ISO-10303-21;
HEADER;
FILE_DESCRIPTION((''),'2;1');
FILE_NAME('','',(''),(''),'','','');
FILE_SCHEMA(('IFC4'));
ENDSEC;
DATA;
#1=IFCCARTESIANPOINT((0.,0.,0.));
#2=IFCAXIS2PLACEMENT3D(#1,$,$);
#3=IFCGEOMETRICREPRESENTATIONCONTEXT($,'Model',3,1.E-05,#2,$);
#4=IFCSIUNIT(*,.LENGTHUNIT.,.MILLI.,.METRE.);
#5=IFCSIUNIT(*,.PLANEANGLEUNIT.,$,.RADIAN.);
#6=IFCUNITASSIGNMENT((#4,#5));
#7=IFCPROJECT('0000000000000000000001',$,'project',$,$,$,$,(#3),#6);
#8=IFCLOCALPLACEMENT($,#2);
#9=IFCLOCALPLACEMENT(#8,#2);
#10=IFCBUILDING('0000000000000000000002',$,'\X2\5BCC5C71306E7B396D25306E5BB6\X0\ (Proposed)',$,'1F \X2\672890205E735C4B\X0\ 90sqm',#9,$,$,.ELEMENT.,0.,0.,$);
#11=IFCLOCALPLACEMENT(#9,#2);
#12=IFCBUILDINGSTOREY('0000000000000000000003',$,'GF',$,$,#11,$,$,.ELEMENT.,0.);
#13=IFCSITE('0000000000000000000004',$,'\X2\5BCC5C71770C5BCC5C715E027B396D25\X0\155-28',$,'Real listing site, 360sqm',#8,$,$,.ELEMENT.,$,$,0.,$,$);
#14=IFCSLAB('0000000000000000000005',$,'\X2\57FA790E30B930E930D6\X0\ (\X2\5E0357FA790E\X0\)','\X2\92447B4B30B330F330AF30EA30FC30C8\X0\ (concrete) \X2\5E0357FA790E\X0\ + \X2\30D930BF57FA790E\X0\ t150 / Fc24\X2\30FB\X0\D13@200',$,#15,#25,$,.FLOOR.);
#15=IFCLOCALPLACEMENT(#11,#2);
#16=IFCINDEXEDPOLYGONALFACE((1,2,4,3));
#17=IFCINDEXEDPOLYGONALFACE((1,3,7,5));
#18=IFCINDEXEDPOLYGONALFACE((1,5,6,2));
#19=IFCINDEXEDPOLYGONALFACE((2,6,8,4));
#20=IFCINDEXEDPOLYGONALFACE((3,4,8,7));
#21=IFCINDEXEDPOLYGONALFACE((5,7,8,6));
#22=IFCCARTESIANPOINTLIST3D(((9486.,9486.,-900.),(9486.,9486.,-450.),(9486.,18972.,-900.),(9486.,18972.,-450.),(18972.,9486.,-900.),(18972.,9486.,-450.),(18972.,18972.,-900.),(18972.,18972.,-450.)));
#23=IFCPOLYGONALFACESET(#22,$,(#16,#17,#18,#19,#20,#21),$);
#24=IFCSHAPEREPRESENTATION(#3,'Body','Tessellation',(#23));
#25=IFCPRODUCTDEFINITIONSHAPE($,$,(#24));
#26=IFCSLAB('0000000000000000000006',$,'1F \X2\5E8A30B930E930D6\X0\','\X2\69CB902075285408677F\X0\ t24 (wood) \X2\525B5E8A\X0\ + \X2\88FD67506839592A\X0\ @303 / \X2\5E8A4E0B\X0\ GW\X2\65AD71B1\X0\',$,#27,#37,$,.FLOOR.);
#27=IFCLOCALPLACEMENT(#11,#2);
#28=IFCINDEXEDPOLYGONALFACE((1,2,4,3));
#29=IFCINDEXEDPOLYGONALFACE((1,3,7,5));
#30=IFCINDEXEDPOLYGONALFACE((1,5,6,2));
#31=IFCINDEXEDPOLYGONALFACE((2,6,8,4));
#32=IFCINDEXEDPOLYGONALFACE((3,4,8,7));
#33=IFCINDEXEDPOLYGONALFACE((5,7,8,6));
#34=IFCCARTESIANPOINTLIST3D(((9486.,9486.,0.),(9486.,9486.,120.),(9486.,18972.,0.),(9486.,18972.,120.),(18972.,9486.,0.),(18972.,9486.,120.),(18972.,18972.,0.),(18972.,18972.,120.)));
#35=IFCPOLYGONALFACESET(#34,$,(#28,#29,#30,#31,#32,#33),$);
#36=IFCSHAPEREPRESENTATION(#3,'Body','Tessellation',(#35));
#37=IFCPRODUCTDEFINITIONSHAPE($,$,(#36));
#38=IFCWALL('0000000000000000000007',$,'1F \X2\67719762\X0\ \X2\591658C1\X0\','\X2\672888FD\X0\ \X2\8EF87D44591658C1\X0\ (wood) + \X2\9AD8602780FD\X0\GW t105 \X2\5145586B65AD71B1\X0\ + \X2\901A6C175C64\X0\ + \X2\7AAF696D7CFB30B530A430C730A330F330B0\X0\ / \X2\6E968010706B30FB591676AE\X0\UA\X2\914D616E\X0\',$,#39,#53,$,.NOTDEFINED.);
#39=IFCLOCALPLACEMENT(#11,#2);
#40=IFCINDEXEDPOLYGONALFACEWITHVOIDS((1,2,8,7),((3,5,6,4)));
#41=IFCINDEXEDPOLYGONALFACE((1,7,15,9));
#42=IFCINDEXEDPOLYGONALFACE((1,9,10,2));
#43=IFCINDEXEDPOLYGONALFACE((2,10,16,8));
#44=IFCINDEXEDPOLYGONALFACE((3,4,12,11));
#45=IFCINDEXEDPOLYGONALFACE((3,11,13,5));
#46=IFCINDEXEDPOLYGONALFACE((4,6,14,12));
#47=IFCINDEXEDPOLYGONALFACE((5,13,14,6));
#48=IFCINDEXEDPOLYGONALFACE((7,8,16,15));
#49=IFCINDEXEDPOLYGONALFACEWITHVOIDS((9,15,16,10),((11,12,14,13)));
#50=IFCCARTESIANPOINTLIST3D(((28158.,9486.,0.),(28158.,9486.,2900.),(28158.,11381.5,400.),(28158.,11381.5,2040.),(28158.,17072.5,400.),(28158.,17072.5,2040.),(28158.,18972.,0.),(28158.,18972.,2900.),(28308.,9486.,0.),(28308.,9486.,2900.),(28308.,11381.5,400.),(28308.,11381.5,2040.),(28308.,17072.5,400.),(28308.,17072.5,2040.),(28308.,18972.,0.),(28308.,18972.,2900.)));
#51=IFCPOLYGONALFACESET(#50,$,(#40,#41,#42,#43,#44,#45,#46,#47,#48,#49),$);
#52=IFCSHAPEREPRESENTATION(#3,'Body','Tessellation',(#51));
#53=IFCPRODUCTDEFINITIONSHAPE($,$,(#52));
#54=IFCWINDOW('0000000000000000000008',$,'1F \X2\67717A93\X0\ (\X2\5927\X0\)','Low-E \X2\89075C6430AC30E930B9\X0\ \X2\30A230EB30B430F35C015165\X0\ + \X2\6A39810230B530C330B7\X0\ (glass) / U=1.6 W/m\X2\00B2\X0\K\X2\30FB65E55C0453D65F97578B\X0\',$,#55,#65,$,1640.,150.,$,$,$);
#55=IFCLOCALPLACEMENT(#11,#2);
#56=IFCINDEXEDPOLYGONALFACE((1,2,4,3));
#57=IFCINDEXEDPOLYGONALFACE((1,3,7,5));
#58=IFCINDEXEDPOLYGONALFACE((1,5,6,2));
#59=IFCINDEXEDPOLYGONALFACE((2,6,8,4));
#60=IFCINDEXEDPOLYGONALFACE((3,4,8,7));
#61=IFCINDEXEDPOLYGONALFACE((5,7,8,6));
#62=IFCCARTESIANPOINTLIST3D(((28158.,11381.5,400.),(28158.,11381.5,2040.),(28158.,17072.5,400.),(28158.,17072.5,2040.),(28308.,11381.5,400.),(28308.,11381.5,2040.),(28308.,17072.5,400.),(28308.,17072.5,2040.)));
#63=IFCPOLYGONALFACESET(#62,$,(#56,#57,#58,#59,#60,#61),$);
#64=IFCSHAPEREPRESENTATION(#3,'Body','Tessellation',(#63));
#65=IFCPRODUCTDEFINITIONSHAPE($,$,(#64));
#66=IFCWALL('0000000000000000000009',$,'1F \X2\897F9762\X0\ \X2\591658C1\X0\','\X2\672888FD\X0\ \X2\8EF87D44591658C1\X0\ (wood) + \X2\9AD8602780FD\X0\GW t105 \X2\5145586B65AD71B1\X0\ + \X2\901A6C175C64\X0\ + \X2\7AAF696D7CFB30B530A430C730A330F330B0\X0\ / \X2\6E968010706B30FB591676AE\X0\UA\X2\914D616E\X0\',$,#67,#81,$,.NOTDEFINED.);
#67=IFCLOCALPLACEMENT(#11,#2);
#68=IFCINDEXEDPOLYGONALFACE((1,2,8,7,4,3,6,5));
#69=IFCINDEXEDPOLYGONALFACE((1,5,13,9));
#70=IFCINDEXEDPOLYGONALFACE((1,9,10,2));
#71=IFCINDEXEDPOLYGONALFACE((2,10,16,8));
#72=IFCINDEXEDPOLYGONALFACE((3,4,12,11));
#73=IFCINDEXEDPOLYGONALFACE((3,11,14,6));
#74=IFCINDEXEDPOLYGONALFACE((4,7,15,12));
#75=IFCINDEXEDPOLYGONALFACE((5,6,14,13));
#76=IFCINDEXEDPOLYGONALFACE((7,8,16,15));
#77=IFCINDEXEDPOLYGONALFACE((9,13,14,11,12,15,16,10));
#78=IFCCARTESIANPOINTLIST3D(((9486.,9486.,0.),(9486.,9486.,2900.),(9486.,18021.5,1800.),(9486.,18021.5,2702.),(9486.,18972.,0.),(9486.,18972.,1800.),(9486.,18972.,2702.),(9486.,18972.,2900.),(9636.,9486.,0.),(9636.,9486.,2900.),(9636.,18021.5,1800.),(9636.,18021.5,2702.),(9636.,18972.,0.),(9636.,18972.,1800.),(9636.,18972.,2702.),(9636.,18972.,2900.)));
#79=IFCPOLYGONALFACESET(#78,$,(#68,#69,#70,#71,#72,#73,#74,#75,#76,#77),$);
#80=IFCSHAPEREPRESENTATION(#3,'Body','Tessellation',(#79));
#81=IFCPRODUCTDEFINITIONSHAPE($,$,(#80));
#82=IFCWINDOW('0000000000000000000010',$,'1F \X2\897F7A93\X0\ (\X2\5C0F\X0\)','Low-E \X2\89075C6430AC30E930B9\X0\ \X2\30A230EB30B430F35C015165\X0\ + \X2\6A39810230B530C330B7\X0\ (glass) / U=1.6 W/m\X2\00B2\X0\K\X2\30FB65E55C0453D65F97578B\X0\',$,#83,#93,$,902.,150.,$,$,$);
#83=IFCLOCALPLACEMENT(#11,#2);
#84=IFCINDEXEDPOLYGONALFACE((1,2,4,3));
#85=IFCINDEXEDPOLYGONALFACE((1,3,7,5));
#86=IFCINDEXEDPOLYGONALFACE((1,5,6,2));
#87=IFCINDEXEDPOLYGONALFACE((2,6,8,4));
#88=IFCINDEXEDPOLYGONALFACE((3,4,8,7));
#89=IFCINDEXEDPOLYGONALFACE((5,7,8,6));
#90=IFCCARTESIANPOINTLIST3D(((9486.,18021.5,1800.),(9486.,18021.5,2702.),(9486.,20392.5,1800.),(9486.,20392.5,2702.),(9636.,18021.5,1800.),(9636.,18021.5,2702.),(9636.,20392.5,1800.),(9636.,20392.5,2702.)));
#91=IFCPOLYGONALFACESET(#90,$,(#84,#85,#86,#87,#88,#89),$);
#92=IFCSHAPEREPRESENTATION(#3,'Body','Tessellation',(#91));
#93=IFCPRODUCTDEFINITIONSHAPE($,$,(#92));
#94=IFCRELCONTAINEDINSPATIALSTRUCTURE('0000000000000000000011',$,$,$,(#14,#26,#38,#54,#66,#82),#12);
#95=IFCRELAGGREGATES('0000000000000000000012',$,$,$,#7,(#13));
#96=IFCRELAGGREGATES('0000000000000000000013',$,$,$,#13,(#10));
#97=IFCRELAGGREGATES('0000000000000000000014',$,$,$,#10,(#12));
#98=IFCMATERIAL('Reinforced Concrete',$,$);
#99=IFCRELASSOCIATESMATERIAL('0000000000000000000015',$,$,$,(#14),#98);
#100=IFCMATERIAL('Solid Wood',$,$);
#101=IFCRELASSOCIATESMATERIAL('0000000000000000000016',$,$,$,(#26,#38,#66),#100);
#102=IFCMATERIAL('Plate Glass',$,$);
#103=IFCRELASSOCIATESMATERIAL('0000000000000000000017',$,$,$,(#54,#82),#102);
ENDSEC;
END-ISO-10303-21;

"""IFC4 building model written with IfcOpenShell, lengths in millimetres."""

from ifc_helpers import new_model, si_unit, frame, frame_2d, origin, place, context, project, spatial, rectangle, extrude, material, element, fill, save


model = new_model("IFC4")

# Units and contexts
model_context = context("Model", 3, precision=1e-05, world=origin())
ifc_project = project(units=[si_unit("LENGTHUNIT", "METRE", prefix="MILLI"), si_unit("PLANEANGLEUNIT", "RADIAN")], contexts=[model_context])

# Site, building, storey
site_placement = place(None, origin())
site = spatial("IfcSite", under=ifc_project, at=site_placement, Name="富山県富山市笹津155-28", ObjectType="Real listing site, 360sqm", CompositionType="ELEMENT", RefElevation=0.0)
building_placement = place(site_placement, origin())
building = spatial("IfcBuilding", under=site, at=building_placement, Name="富山の笹津の家 (Proposed)", ObjectType="1F 木造平屋 90sqm", CompositionType="ELEMENT", ElevationOfRefHeight=0.0, ElevationOfTerrain=0.0)
storey_placement = place(building_placement, origin())
storey = spatial("IfcBuildingStorey", under=building, at=storey_placement, Name="GF", CompositionType="ELEMENT", Elevation=0.0)

# Slabs
ifc_material_1 = material(Name="Reinforced Concrete")
slab_1_placement = place(storey_placement, frame((4743.0, 4743.0, -450.0)))
element("IfcSlab", 1, at=slab_1_placement, inside=storey, material=ifc_material_1, Name="基礎スラブ (布基礎)", Description="鉄筋コンクリート (concrete) 布基礎 + ベタ基礎 t150 / Fc24・D13@200", PredefinedType="FLOOR", context=model_context, shape_type="SweptSolid", body=[
    extrude(rectangle(XDim=9486.0, YDim=9486.0, at=frame_2d((4743.0, 4743.0))), frame((4743.0, 4743.0, -450.0)), (0.0, 0.0, 1.0), 450.0),
])
ifc_material_2 = material(Name="Solid Wood")
slab_2_placement = place(storey_placement, frame((4743.0, 4743.0, 0.0)))
element("IfcSlab", 2, at=slab_2_placement, inside=storey, material=ifc_material_2, Name="1F 床スラブ", Description="構造用合板 t24 (wood) 剛床 + 製材根太 @303 / 床下 GW断熱", PredefinedType="FLOOR", context=model_context, shape_type="SweptSolid", body=[
    extrude(rectangle(XDim=9486.0, YDim=9486.0, at=frame_2d((4743.0, 4743.0))), frame((4743.0, 4743.0, 0.0)), (0.0, 0.0, 1.0), 120.0),
])

# Shared definitions
ifc_material_3 = material(Name="Plate Glass")

# Walls, openings, windows
wall_1_placement = place(storey_placement, frame((14079.0, 4743.0, 0.0)))
wall_1 = element("IfcWall", 3, at=wall_1_placement, inside=storey, material=ifc_material_2, Name="1F 東面 外壁", Description="木製 軸組外壁 (wood) + 高性能GW t105 充填断熱 + 通気層 + 窯業系サイディング / 準耐火・外皮UA配慮", PredefinedType="NOTDEFINED", context=model_context, shape_type="SweptSolid", body=[
    extrude(rectangle(XDim=150.0, YDim=9486.0, at=frame_2d((75.0, 4743.0))), frame((14079.0, 4743.0, 0.0)), (0.0, 0.0, 1.0), 2900.0),
])
opening_1_placement = place(storey_placement, frame((14079.0, 5691.0, 200.0)))
opening_1 = element("IfcOpeningElement", 4, at=opening_1_placement, cuts=wall_1, PredefinedType="NOTDEFINED", context=model_context, shape_type="SweptSolid", body=[
    extrude(rectangle(XDim=150.0, YDim=5691.0, at=frame_2d((75.0, 2845.0))), frame((14079.0, 5691.0, 200.0)), (0.0, 0.0, 1.0), 1640.0),
])
window_1_placement = place(storey_placement, frame((14079.0, 5691.0, 200.0)))
window_1 = element("IfcWindow", 5, at=window_1_placement, inside=storey, material=ifc_material_3, Name="1F 東窓 (大)", Description="Low-E 複層ガラス アルゴン封入 + 樹脂サッシ (glass) / U=1.6 W/m²K・日射取得型", OverallHeight=1640.0, OverallWidth=150.0, context=model_context, shape_type="SweptSolid", body=[
    extrude(rectangle(XDim=150.0, YDim=5691.0, at=frame_2d((75.0, 2845.0))), frame((14079.0, 5691.0, 200.0)), (0.0, 0.0, 1.0), 1640.0),
])
fill(opening_1, window_1)
wall_2_placement = place(storey_placement, frame((4743.0, 4743.0, 0.0)))
wall_2 = element("IfcWall", 6, at=wall_2_placement, inside=storey, material=ifc_material_2, Name="1F 西面 外壁", Description="木製 軸組外壁 (wood) + 高性能GW t105 充填断熱 + 通気層 + 窯業系サイディング / 準耐火・外皮UA配慮", PredefinedType="NOTDEFINED", context=model_context, shape_type="SweptSolid", body=[
    extrude(rectangle(XDim=150.0, YDim=9486.0, at=frame_2d((75.0, 4743.0))), frame((4743.0, 4743.0, 0.0)), (0.0, 0.0, 1.0), 2900.0),
])
opening_2_placement = place(storey_placement, frame((4743.0, 9011.0, 900.0)))
opening_2 = element("IfcOpeningElement", 7, at=opening_2_placement, cuts=wall_2, PredefinedType="NOTDEFINED", context=model_context, shape_type="SweptSolid", body=[
    extrude(rectangle(XDim=150.0, YDim=2371.0, at=frame_2d((75.0, 1185.0))), frame((4743.0, 9011.0, 900.0)), (0.0, 0.0, 1.0), 902.0),
])
window_2_placement = place(storey_placement, frame((4743.0, 9011.0, 900.0)))
window_2 = element("IfcWindow", 8, at=window_2_placement, inside=storey, material=ifc_material_3, Name="1F 西窓 (小)", Description="Low-E 複層ガラス アルゴン封入 + 樹脂サッシ (glass) / U=1.6 W/m²K・日射取得型", OverallHeight=902.0, OverallWidth=150.0, context=model_context, shape_type="SweptSolid", body=[
    extrude(rectangle(XDim=150.0, YDim=2371.0, at=frame_2d((75.0, 1185.0))), frame((4743.0, 9011.0, 900.0)), (0.0, 0.0, 1.0), 902.0),
])
fill(opening_2, window_2)

save(model, "model.ifc")
